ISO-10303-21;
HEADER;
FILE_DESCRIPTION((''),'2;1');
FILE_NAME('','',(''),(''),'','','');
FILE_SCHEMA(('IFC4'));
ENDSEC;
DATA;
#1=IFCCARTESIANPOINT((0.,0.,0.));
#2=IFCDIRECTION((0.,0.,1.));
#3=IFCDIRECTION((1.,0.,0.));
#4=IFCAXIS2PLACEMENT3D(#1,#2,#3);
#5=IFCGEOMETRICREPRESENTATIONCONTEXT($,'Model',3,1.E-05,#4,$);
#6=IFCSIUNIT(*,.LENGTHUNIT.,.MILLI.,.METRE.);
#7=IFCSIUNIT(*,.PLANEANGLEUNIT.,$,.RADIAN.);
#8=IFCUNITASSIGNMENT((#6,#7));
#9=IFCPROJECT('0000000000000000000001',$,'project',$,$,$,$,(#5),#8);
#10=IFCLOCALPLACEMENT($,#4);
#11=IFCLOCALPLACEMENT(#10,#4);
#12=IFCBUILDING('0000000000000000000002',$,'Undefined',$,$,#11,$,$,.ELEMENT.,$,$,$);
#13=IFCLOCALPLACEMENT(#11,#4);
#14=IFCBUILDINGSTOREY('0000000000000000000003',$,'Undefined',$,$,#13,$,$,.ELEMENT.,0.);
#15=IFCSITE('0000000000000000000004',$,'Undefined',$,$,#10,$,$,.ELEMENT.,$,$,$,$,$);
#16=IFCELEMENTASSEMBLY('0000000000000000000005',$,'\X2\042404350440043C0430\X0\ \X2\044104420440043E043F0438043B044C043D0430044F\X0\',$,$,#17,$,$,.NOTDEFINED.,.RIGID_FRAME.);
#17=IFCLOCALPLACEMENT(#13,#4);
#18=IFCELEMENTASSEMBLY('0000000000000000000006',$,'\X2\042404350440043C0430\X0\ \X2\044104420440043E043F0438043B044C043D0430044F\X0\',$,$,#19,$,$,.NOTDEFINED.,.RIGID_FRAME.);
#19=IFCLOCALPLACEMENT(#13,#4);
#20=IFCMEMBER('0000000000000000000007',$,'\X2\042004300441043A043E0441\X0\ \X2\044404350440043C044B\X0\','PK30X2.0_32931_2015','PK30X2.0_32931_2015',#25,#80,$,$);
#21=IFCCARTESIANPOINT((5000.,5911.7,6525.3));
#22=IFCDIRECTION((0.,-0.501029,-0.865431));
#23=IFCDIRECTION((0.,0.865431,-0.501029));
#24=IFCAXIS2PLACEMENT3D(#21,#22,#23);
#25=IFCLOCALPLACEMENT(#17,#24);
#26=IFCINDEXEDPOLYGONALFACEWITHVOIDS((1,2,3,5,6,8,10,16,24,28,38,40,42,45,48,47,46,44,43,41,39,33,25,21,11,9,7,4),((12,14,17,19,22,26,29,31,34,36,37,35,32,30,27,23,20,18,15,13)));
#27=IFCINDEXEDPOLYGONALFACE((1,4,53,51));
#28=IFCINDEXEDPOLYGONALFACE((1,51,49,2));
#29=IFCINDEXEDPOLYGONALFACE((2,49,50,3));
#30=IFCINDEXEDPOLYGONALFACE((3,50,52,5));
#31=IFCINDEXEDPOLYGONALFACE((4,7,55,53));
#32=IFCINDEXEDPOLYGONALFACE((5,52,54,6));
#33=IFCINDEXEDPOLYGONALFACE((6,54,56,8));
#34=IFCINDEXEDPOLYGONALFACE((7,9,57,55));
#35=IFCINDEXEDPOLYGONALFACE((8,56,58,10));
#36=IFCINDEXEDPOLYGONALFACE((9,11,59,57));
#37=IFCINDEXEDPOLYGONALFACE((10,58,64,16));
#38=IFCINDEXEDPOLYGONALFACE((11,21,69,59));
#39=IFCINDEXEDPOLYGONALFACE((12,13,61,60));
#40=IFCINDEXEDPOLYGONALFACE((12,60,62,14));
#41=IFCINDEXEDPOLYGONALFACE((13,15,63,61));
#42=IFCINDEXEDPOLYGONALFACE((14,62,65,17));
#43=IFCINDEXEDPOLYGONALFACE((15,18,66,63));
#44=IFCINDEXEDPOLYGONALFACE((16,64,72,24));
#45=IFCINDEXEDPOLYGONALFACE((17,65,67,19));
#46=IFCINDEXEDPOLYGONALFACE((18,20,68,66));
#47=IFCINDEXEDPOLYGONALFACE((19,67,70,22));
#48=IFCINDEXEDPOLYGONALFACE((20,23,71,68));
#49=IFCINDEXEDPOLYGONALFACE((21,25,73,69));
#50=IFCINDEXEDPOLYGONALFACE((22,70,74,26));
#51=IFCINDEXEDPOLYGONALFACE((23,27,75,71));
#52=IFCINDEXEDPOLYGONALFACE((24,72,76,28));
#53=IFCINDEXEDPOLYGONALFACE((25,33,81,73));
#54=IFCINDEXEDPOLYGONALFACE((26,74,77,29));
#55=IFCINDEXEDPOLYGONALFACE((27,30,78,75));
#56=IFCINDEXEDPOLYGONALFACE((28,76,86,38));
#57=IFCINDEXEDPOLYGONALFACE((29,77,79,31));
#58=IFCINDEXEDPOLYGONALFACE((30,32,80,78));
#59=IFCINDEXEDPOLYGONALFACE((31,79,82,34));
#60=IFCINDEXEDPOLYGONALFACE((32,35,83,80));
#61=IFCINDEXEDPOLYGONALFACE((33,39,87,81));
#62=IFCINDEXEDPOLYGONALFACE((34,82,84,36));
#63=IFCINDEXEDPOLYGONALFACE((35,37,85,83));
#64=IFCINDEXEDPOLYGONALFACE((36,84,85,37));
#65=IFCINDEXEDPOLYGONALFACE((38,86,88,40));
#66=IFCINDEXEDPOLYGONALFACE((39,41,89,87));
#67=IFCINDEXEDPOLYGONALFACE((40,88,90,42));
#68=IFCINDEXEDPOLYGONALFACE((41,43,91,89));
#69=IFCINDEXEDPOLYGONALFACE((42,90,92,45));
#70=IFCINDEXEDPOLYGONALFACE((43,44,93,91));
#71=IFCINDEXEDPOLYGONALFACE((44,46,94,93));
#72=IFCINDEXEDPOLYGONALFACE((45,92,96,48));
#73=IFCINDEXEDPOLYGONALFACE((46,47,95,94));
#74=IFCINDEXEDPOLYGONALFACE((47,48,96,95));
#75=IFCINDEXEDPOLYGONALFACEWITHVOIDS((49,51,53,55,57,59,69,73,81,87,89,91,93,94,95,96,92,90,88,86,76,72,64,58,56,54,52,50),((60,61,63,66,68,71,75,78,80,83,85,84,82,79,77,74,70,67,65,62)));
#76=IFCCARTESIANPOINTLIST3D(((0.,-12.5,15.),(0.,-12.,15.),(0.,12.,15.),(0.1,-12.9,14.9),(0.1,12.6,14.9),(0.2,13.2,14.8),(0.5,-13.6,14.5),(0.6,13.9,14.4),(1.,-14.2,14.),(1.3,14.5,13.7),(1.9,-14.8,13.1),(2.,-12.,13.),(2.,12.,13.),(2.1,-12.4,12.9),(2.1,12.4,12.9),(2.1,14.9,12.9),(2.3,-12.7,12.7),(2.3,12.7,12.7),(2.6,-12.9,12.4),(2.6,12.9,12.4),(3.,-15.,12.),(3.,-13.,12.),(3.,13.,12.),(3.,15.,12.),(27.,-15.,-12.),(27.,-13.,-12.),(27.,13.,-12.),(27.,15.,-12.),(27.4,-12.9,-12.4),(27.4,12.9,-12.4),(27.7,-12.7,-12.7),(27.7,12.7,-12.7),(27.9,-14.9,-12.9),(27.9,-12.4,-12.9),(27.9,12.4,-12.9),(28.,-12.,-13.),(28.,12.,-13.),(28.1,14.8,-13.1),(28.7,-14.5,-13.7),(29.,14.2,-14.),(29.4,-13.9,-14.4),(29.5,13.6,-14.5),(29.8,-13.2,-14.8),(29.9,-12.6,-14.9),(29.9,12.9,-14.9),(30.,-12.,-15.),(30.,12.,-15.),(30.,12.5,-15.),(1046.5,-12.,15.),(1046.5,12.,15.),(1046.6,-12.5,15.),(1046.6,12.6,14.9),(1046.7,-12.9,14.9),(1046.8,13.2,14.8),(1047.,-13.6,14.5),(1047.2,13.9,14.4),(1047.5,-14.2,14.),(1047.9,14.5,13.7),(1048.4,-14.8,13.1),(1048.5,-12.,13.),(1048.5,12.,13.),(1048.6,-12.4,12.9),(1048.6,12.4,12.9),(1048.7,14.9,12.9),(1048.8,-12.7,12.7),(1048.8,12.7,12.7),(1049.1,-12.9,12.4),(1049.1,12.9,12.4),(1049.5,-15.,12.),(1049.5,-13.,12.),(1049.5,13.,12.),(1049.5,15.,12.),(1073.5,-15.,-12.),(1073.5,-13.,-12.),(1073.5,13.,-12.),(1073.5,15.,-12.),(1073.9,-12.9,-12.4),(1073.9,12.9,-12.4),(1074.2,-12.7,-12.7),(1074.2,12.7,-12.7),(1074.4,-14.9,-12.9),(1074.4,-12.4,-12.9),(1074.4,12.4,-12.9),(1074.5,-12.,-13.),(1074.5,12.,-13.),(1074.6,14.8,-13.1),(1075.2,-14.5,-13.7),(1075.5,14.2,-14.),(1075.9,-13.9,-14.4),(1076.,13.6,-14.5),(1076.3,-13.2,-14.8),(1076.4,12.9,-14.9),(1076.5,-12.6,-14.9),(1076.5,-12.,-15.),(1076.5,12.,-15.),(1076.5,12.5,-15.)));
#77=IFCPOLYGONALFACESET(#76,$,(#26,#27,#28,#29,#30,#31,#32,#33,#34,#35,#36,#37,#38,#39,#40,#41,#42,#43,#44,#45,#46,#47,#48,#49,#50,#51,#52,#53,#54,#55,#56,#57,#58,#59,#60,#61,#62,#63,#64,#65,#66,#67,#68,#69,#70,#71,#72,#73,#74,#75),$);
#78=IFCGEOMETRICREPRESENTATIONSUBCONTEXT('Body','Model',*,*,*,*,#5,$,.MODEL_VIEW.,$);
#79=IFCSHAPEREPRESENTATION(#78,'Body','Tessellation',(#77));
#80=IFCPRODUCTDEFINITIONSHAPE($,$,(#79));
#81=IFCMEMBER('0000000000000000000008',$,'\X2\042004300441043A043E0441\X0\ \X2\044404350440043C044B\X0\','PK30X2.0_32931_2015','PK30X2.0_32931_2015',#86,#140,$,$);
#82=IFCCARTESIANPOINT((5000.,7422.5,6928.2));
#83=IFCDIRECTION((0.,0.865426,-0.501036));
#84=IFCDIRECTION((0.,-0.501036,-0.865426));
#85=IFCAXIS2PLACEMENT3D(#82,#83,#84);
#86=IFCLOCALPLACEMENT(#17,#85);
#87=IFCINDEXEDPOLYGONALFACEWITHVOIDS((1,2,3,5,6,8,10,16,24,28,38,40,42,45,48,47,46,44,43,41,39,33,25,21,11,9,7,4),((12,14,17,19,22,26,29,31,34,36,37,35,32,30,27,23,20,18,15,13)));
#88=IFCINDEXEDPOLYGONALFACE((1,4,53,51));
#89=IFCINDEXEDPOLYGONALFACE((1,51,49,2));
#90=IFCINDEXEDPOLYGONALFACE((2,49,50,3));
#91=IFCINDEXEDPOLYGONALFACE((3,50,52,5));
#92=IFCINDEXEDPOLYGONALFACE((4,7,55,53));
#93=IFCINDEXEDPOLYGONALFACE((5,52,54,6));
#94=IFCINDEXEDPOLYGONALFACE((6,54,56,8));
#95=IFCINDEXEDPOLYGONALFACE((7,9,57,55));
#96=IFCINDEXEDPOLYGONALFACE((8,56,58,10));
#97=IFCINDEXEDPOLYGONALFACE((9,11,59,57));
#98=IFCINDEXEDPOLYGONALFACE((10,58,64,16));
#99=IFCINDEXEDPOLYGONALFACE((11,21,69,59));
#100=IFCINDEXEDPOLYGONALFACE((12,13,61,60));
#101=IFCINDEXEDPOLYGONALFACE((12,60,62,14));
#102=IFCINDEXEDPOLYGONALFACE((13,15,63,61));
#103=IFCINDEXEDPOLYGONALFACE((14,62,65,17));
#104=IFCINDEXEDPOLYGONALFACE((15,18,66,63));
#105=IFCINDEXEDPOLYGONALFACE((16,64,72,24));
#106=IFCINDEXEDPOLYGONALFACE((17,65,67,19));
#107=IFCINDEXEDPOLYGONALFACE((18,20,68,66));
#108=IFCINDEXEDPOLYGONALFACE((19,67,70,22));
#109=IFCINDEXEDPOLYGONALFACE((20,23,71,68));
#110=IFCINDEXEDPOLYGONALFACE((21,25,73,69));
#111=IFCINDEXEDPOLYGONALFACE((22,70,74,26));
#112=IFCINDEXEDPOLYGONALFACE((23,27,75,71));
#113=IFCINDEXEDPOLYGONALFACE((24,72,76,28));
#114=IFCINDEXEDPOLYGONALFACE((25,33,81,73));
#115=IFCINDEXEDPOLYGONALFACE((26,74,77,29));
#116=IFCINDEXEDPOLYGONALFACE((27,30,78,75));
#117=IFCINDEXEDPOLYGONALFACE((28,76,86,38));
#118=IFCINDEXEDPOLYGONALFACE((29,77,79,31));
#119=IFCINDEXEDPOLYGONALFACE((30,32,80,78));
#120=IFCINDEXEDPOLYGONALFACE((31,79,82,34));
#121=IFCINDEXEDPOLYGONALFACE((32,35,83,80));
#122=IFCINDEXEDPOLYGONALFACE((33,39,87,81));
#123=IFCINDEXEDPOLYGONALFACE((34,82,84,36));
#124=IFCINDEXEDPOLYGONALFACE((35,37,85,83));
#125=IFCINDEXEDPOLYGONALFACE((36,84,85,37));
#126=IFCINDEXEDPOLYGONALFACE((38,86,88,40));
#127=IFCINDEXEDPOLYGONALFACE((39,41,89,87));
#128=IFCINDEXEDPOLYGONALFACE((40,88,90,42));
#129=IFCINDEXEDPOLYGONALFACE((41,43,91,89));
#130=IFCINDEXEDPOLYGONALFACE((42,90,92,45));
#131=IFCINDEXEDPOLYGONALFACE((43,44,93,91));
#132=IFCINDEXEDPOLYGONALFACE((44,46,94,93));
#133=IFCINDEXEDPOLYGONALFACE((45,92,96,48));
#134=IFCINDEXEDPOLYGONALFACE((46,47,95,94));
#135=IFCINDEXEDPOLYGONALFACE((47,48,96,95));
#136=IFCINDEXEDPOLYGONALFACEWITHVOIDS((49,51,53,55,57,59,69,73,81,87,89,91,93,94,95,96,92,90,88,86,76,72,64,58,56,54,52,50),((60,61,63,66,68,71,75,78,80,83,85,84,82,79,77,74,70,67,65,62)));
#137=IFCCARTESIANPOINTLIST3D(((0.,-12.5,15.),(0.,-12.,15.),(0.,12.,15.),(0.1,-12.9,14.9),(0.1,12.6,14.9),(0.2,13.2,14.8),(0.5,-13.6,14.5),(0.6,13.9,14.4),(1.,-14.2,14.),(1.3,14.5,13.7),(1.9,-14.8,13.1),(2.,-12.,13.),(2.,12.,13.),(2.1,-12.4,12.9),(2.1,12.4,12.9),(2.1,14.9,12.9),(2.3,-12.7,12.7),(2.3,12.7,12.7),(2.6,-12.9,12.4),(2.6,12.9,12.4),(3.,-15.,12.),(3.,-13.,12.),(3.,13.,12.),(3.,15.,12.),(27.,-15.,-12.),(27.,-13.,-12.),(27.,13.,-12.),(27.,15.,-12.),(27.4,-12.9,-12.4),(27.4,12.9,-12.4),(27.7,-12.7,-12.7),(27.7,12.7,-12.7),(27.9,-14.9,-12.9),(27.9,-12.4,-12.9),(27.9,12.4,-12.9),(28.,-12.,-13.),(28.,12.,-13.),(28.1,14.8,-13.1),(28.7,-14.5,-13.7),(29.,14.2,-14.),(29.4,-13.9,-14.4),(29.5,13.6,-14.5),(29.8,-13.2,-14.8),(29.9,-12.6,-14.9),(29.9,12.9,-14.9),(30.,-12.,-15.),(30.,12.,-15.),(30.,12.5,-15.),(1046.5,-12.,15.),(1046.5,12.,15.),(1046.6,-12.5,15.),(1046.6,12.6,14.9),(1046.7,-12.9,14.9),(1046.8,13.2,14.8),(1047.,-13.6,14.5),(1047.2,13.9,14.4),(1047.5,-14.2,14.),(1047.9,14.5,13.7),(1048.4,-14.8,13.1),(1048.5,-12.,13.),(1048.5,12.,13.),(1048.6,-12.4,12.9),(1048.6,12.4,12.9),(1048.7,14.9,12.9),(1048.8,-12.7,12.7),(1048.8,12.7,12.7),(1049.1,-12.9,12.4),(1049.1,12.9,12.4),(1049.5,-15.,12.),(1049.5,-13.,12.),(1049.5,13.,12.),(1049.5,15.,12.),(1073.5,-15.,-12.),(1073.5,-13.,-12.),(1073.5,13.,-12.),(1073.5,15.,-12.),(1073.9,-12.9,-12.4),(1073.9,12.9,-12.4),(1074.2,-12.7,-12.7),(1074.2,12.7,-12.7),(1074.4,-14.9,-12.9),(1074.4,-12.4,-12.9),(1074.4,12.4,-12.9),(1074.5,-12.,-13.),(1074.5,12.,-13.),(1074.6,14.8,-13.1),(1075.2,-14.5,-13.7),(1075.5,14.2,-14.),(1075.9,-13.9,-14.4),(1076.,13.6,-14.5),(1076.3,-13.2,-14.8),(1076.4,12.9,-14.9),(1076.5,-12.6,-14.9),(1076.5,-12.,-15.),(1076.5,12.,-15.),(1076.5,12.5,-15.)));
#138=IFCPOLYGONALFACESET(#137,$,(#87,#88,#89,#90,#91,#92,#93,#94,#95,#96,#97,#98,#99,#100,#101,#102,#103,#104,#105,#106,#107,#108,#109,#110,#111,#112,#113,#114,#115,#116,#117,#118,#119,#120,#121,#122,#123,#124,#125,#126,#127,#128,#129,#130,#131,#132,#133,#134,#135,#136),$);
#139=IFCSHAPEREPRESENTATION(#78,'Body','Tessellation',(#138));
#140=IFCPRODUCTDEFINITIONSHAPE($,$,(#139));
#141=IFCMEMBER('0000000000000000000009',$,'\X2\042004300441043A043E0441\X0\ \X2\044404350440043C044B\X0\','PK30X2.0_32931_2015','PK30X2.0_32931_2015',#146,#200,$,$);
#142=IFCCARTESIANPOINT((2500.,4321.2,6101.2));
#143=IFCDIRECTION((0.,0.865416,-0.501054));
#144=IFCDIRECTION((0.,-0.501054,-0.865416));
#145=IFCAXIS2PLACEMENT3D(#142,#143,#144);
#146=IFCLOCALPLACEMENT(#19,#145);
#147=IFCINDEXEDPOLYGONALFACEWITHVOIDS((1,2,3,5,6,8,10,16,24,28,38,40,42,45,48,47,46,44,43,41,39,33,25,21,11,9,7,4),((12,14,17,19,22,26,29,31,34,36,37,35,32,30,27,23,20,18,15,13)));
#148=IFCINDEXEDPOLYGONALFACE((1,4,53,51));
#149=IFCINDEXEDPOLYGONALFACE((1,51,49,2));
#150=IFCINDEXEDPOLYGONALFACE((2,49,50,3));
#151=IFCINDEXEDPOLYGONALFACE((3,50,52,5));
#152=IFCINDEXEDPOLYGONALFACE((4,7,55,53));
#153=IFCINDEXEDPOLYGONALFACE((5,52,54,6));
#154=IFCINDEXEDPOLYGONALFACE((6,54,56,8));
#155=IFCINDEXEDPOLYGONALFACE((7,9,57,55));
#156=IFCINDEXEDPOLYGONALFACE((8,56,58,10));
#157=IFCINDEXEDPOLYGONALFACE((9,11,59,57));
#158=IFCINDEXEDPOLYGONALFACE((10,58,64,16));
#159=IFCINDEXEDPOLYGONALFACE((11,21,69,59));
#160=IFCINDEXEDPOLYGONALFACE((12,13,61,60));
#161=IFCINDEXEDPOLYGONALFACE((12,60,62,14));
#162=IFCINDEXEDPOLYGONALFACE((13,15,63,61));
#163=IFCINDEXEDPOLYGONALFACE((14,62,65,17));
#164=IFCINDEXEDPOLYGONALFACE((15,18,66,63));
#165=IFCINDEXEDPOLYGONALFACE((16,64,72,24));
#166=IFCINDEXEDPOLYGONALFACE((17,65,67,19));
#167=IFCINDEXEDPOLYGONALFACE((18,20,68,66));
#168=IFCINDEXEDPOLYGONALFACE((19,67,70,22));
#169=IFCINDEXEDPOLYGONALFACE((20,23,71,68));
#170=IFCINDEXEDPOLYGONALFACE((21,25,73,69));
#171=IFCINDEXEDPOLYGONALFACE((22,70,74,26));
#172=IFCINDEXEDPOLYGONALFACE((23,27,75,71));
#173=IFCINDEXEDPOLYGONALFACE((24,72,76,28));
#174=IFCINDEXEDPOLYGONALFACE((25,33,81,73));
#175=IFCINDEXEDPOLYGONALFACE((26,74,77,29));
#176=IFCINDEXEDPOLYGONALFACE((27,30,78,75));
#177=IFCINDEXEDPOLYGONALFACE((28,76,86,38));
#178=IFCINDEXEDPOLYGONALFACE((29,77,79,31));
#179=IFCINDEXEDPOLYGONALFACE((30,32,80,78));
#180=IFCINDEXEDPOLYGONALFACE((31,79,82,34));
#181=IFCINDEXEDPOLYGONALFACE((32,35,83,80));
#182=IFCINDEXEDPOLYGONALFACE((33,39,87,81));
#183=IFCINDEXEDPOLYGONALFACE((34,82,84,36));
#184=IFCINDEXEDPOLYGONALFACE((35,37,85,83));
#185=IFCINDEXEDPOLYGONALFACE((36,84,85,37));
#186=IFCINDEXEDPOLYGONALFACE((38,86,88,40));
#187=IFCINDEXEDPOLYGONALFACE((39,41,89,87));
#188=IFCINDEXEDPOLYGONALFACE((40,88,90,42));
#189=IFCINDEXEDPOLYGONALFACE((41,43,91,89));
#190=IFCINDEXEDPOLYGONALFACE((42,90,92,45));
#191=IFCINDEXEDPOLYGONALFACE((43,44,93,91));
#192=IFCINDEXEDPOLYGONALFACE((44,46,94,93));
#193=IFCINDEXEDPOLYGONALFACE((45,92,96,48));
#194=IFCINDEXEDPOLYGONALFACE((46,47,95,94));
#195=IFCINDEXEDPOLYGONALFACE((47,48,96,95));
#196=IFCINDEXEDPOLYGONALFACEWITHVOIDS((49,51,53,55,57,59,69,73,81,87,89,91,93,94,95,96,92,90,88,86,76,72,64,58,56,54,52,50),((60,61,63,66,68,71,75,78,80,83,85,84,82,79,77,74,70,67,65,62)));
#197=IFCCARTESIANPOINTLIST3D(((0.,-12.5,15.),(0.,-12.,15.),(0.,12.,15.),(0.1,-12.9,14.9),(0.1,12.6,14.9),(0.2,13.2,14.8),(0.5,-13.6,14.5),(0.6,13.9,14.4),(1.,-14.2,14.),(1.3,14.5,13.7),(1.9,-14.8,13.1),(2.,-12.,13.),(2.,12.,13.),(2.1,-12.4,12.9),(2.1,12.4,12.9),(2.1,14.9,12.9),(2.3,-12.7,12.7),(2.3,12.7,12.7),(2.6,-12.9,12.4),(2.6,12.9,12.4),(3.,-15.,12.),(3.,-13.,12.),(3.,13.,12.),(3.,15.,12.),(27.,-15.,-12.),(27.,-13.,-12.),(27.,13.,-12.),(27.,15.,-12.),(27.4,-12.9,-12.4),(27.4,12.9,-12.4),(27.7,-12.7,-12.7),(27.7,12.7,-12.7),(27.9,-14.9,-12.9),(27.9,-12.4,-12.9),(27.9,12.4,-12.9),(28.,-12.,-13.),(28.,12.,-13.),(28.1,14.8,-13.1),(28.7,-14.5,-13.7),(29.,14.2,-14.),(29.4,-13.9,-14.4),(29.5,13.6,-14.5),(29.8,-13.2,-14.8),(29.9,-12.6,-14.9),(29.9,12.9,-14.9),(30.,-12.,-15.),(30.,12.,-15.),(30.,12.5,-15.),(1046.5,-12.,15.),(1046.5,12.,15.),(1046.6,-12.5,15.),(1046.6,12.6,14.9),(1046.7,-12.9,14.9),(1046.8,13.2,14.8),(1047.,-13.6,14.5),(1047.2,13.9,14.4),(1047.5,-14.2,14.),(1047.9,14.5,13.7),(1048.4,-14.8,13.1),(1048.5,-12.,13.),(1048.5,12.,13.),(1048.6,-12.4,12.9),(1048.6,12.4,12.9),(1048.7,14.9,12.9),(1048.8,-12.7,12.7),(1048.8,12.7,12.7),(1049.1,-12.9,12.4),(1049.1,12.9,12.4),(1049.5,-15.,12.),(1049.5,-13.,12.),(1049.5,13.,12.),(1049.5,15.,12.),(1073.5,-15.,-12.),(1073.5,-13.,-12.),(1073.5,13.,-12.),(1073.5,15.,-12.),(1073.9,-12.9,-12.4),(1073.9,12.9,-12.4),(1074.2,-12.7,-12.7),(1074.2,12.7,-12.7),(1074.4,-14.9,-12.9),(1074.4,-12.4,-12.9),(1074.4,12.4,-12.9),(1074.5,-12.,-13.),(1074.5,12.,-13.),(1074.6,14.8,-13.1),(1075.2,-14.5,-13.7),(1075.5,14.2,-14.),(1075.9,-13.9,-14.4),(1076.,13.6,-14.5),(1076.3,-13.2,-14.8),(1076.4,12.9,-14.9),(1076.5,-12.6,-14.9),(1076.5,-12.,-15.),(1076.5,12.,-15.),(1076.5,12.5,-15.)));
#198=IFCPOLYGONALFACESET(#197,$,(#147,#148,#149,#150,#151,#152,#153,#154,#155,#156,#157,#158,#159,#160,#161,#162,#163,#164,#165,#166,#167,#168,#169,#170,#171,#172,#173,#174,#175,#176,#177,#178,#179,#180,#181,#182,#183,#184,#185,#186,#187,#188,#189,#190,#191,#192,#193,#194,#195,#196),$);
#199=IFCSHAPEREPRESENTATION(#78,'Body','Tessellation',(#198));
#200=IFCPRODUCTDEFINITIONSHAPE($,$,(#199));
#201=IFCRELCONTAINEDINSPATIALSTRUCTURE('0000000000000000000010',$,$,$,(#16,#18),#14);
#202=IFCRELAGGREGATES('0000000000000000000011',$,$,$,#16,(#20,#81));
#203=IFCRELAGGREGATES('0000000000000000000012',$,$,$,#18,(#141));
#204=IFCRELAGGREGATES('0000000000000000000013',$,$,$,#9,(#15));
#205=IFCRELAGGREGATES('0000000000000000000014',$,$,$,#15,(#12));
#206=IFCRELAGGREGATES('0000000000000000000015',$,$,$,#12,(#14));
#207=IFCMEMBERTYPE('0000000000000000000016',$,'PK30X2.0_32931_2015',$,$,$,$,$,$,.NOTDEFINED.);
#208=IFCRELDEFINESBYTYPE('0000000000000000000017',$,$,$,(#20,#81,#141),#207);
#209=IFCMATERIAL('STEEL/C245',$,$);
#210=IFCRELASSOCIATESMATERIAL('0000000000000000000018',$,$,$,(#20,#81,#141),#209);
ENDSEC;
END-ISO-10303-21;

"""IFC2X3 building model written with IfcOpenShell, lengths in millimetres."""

from ifc_helpers import new_model, si_unit, frame, origin_with_axes, origin_2d_with_axis, place, context, subcontext, project, spatial, hollow_rectangle, extrude, clip, halfspace, material, type_object, element, aggregate, save


model = new_model("IFC2X3")

# Units and contexts
model_context = context("Model", 3, precision=1e-05, world=origin_with_axes())
body_context = subcontext(model_context, "Body", "Model", "MODEL_VIEW")
ifc_project = project(units=[si_unit("LENGTHUNIT", "METRE", prefix="MILLI"), si_unit("PLANEANGLEUNIT", "RADIAN")], contexts=[model_context])

# Site, building, storey
site_placement = place(None, origin_with_axes())
site = spatial("IfcSite", under=ifc_project, at=site_placement, Name="Undefined", CompositionType="ELEMENT")
building_placement = place(site_placement, origin_with_axes())
building = spatial("IfcBuilding", under=site, at=building_placement, Name="Undefined", CompositionType="ELEMENT")
storey_placement = place(building_placement, origin_with_axes())
storey = spatial("IfcBuildingStorey", under=building, at=storey_placement, Name="Undefined", CompositionType="ELEMENT", Elevation=0.0)

# Element assemblies
assembly_1_placement = place(storey_placement, origin_with_axes())
assembly_1 = element("IfcElementAssembly", 1, at=assembly_1_placement, inside=storey, Name="Ферма стропильная", AssemblyPlace="NOTDEFINED", PredefinedType="RIGID_FRAME")
ifc_material_1 = material(Name="STEEL/C245")
assembly_2_placement = place(storey_placement, origin_with_axes())
assembly_2 = element("IfcElementAssembly", 2, at=assembly_2_placement, inside=storey, Name="Ферма стропильная", AssemblyPlace="NOTDEFINED", PredefinedType="RIGID_FRAME")

# Members
member_type = type_object("IfcMemberType", Name="PK30X2.0_32931_2015", PredefinedType="NOTDEFINED")
member_1_placement = place(assembly_1_placement, frame((5000.0, 5911.7, 6525.3), z_axis=(0.0, -0.501029, -0.865431), x_axis=(0.0, 0.865431, -0.501029)))
member_1 = element("IfcMember", 3, at=member_1_placement, type_object=member_type, material=ifc_material_1, Name="Раскос фермы", Description="PK30X2.0_32931_2015", ObjectType="PK30X2.0_32931_2015", context=body_context, shape_type="Clipping", body=[
    clip(clip(extrude(hollow_rectangle(XDim=30.0, YDim=30.0, WallThickness=2.0, InnerFilletRadius=1.0, OuterFilletRadius=3.0, at=origin_2d_with_axis()), frame((1102.9, 0.0, 0.0), z_axis=(-1.0, 0.0, 0.0), x_axis=(0.0, -1.0, 0.0)), (0.0, 0.0, 1.0), 1129.2), halfspace(frame((1060.0, 0.0, 1.5), z_axis=(-0.707107, 0.0, -0.707107), x_axis=(0.0, -1.0, 0.0)), True)), halfspace(frame((34.5, 0.0, -19.5), z_axis=(-0.707107, 0.0, -0.707107), x_axis=(0.0, -1.0, 0.0)), False)),
])
member_2_placement = place(assembly_1_placement, frame((5000.0, 7422.5, 6928.2), z_axis=(0.0, 0.865426, -0.501036), x_axis=(0.0, -0.501036, -0.865426)))
member_2 = element("IfcMember", 4, at=member_2_placement, type_object=member_type, material=ifc_material_1, Name="Раскос фермы", Description="PK30X2.0_32931_2015", ObjectType="PK30X2.0_32931_2015", context=body_context, shape_type="Clipping", body=[
    clip(clip(extrude(hollow_rectangle(XDim=30.0, YDim=30.0, WallThickness=2.0, InnerFilletRadius=1.0, OuterFilletRadius=3.0, at=origin_2d_with_axis()), frame((1091.8, 0.0, 0.0), z_axis=(-1.0, 0.0, 0.0), x_axis=(0.0, -1.0, 0.0)), (0.0, 0.0, 1.0), 1107.1), halfspace(frame((1060.0, 0.0, 1.5), z_axis=(-0.707107, 0.0, -0.707107), x_axis=(0.0, -1.0, 0.0)), True)), halfspace(frame((34.5, 0.0, -19.5), z_axis=(-0.707107, 0.0, -0.707107), x_axis=(0.0, -1.0, 0.0)), False)),
])
aggregate(assembly_1, [member_1, member_2])
member_3_placement = place(assembly_2_placement, frame((2500.0, 4321.2, 6101.2), z_axis=(0.0, 0.865416, -0.501054), x_axis=(0.0, -0.501054, -0.865416)))
member_3 = element("IfcMember", 5, at=member_3_placement, type_object=member_type, material=ifc_material_1, Name="Раскос фермы", Description="PK30X2.0_32931_2015", ObjectType="PK30X2.0_32931_2015", context=body_context, shape_type="Clipping", body=[
    clip(clip(extrude(hollow_rectangle(XDim=30.0, YDim=30.0, WallThickness=2.0, InnerFilletRadius=1.0, OuterFilletRadius=3.0, at=origin_2d_with_axis()), frame((1091.8, 0.0, 0.0), z_axis=(-1.0, 0.0, 0.0), x_axis=(0.0, -1.0, 0.0)), (0.0, 0.0, 1.0), 1107.1), halfspace(frame((1060.0, 0.0, 1.5), z_axis=(-0.707107, 0.0, -0.707107), x_axis=(0.0, -1.0, 0.0)), True)), halfspace(frame((34.5, 0.0, -19.5), z_axis=(-0.707107, 0.0, -0.707107), x_axis=(0.0, -1.0, 0.0)), False)),
])
aggregate(assembly_2, [member_3])

save(model, "model.ifc")
